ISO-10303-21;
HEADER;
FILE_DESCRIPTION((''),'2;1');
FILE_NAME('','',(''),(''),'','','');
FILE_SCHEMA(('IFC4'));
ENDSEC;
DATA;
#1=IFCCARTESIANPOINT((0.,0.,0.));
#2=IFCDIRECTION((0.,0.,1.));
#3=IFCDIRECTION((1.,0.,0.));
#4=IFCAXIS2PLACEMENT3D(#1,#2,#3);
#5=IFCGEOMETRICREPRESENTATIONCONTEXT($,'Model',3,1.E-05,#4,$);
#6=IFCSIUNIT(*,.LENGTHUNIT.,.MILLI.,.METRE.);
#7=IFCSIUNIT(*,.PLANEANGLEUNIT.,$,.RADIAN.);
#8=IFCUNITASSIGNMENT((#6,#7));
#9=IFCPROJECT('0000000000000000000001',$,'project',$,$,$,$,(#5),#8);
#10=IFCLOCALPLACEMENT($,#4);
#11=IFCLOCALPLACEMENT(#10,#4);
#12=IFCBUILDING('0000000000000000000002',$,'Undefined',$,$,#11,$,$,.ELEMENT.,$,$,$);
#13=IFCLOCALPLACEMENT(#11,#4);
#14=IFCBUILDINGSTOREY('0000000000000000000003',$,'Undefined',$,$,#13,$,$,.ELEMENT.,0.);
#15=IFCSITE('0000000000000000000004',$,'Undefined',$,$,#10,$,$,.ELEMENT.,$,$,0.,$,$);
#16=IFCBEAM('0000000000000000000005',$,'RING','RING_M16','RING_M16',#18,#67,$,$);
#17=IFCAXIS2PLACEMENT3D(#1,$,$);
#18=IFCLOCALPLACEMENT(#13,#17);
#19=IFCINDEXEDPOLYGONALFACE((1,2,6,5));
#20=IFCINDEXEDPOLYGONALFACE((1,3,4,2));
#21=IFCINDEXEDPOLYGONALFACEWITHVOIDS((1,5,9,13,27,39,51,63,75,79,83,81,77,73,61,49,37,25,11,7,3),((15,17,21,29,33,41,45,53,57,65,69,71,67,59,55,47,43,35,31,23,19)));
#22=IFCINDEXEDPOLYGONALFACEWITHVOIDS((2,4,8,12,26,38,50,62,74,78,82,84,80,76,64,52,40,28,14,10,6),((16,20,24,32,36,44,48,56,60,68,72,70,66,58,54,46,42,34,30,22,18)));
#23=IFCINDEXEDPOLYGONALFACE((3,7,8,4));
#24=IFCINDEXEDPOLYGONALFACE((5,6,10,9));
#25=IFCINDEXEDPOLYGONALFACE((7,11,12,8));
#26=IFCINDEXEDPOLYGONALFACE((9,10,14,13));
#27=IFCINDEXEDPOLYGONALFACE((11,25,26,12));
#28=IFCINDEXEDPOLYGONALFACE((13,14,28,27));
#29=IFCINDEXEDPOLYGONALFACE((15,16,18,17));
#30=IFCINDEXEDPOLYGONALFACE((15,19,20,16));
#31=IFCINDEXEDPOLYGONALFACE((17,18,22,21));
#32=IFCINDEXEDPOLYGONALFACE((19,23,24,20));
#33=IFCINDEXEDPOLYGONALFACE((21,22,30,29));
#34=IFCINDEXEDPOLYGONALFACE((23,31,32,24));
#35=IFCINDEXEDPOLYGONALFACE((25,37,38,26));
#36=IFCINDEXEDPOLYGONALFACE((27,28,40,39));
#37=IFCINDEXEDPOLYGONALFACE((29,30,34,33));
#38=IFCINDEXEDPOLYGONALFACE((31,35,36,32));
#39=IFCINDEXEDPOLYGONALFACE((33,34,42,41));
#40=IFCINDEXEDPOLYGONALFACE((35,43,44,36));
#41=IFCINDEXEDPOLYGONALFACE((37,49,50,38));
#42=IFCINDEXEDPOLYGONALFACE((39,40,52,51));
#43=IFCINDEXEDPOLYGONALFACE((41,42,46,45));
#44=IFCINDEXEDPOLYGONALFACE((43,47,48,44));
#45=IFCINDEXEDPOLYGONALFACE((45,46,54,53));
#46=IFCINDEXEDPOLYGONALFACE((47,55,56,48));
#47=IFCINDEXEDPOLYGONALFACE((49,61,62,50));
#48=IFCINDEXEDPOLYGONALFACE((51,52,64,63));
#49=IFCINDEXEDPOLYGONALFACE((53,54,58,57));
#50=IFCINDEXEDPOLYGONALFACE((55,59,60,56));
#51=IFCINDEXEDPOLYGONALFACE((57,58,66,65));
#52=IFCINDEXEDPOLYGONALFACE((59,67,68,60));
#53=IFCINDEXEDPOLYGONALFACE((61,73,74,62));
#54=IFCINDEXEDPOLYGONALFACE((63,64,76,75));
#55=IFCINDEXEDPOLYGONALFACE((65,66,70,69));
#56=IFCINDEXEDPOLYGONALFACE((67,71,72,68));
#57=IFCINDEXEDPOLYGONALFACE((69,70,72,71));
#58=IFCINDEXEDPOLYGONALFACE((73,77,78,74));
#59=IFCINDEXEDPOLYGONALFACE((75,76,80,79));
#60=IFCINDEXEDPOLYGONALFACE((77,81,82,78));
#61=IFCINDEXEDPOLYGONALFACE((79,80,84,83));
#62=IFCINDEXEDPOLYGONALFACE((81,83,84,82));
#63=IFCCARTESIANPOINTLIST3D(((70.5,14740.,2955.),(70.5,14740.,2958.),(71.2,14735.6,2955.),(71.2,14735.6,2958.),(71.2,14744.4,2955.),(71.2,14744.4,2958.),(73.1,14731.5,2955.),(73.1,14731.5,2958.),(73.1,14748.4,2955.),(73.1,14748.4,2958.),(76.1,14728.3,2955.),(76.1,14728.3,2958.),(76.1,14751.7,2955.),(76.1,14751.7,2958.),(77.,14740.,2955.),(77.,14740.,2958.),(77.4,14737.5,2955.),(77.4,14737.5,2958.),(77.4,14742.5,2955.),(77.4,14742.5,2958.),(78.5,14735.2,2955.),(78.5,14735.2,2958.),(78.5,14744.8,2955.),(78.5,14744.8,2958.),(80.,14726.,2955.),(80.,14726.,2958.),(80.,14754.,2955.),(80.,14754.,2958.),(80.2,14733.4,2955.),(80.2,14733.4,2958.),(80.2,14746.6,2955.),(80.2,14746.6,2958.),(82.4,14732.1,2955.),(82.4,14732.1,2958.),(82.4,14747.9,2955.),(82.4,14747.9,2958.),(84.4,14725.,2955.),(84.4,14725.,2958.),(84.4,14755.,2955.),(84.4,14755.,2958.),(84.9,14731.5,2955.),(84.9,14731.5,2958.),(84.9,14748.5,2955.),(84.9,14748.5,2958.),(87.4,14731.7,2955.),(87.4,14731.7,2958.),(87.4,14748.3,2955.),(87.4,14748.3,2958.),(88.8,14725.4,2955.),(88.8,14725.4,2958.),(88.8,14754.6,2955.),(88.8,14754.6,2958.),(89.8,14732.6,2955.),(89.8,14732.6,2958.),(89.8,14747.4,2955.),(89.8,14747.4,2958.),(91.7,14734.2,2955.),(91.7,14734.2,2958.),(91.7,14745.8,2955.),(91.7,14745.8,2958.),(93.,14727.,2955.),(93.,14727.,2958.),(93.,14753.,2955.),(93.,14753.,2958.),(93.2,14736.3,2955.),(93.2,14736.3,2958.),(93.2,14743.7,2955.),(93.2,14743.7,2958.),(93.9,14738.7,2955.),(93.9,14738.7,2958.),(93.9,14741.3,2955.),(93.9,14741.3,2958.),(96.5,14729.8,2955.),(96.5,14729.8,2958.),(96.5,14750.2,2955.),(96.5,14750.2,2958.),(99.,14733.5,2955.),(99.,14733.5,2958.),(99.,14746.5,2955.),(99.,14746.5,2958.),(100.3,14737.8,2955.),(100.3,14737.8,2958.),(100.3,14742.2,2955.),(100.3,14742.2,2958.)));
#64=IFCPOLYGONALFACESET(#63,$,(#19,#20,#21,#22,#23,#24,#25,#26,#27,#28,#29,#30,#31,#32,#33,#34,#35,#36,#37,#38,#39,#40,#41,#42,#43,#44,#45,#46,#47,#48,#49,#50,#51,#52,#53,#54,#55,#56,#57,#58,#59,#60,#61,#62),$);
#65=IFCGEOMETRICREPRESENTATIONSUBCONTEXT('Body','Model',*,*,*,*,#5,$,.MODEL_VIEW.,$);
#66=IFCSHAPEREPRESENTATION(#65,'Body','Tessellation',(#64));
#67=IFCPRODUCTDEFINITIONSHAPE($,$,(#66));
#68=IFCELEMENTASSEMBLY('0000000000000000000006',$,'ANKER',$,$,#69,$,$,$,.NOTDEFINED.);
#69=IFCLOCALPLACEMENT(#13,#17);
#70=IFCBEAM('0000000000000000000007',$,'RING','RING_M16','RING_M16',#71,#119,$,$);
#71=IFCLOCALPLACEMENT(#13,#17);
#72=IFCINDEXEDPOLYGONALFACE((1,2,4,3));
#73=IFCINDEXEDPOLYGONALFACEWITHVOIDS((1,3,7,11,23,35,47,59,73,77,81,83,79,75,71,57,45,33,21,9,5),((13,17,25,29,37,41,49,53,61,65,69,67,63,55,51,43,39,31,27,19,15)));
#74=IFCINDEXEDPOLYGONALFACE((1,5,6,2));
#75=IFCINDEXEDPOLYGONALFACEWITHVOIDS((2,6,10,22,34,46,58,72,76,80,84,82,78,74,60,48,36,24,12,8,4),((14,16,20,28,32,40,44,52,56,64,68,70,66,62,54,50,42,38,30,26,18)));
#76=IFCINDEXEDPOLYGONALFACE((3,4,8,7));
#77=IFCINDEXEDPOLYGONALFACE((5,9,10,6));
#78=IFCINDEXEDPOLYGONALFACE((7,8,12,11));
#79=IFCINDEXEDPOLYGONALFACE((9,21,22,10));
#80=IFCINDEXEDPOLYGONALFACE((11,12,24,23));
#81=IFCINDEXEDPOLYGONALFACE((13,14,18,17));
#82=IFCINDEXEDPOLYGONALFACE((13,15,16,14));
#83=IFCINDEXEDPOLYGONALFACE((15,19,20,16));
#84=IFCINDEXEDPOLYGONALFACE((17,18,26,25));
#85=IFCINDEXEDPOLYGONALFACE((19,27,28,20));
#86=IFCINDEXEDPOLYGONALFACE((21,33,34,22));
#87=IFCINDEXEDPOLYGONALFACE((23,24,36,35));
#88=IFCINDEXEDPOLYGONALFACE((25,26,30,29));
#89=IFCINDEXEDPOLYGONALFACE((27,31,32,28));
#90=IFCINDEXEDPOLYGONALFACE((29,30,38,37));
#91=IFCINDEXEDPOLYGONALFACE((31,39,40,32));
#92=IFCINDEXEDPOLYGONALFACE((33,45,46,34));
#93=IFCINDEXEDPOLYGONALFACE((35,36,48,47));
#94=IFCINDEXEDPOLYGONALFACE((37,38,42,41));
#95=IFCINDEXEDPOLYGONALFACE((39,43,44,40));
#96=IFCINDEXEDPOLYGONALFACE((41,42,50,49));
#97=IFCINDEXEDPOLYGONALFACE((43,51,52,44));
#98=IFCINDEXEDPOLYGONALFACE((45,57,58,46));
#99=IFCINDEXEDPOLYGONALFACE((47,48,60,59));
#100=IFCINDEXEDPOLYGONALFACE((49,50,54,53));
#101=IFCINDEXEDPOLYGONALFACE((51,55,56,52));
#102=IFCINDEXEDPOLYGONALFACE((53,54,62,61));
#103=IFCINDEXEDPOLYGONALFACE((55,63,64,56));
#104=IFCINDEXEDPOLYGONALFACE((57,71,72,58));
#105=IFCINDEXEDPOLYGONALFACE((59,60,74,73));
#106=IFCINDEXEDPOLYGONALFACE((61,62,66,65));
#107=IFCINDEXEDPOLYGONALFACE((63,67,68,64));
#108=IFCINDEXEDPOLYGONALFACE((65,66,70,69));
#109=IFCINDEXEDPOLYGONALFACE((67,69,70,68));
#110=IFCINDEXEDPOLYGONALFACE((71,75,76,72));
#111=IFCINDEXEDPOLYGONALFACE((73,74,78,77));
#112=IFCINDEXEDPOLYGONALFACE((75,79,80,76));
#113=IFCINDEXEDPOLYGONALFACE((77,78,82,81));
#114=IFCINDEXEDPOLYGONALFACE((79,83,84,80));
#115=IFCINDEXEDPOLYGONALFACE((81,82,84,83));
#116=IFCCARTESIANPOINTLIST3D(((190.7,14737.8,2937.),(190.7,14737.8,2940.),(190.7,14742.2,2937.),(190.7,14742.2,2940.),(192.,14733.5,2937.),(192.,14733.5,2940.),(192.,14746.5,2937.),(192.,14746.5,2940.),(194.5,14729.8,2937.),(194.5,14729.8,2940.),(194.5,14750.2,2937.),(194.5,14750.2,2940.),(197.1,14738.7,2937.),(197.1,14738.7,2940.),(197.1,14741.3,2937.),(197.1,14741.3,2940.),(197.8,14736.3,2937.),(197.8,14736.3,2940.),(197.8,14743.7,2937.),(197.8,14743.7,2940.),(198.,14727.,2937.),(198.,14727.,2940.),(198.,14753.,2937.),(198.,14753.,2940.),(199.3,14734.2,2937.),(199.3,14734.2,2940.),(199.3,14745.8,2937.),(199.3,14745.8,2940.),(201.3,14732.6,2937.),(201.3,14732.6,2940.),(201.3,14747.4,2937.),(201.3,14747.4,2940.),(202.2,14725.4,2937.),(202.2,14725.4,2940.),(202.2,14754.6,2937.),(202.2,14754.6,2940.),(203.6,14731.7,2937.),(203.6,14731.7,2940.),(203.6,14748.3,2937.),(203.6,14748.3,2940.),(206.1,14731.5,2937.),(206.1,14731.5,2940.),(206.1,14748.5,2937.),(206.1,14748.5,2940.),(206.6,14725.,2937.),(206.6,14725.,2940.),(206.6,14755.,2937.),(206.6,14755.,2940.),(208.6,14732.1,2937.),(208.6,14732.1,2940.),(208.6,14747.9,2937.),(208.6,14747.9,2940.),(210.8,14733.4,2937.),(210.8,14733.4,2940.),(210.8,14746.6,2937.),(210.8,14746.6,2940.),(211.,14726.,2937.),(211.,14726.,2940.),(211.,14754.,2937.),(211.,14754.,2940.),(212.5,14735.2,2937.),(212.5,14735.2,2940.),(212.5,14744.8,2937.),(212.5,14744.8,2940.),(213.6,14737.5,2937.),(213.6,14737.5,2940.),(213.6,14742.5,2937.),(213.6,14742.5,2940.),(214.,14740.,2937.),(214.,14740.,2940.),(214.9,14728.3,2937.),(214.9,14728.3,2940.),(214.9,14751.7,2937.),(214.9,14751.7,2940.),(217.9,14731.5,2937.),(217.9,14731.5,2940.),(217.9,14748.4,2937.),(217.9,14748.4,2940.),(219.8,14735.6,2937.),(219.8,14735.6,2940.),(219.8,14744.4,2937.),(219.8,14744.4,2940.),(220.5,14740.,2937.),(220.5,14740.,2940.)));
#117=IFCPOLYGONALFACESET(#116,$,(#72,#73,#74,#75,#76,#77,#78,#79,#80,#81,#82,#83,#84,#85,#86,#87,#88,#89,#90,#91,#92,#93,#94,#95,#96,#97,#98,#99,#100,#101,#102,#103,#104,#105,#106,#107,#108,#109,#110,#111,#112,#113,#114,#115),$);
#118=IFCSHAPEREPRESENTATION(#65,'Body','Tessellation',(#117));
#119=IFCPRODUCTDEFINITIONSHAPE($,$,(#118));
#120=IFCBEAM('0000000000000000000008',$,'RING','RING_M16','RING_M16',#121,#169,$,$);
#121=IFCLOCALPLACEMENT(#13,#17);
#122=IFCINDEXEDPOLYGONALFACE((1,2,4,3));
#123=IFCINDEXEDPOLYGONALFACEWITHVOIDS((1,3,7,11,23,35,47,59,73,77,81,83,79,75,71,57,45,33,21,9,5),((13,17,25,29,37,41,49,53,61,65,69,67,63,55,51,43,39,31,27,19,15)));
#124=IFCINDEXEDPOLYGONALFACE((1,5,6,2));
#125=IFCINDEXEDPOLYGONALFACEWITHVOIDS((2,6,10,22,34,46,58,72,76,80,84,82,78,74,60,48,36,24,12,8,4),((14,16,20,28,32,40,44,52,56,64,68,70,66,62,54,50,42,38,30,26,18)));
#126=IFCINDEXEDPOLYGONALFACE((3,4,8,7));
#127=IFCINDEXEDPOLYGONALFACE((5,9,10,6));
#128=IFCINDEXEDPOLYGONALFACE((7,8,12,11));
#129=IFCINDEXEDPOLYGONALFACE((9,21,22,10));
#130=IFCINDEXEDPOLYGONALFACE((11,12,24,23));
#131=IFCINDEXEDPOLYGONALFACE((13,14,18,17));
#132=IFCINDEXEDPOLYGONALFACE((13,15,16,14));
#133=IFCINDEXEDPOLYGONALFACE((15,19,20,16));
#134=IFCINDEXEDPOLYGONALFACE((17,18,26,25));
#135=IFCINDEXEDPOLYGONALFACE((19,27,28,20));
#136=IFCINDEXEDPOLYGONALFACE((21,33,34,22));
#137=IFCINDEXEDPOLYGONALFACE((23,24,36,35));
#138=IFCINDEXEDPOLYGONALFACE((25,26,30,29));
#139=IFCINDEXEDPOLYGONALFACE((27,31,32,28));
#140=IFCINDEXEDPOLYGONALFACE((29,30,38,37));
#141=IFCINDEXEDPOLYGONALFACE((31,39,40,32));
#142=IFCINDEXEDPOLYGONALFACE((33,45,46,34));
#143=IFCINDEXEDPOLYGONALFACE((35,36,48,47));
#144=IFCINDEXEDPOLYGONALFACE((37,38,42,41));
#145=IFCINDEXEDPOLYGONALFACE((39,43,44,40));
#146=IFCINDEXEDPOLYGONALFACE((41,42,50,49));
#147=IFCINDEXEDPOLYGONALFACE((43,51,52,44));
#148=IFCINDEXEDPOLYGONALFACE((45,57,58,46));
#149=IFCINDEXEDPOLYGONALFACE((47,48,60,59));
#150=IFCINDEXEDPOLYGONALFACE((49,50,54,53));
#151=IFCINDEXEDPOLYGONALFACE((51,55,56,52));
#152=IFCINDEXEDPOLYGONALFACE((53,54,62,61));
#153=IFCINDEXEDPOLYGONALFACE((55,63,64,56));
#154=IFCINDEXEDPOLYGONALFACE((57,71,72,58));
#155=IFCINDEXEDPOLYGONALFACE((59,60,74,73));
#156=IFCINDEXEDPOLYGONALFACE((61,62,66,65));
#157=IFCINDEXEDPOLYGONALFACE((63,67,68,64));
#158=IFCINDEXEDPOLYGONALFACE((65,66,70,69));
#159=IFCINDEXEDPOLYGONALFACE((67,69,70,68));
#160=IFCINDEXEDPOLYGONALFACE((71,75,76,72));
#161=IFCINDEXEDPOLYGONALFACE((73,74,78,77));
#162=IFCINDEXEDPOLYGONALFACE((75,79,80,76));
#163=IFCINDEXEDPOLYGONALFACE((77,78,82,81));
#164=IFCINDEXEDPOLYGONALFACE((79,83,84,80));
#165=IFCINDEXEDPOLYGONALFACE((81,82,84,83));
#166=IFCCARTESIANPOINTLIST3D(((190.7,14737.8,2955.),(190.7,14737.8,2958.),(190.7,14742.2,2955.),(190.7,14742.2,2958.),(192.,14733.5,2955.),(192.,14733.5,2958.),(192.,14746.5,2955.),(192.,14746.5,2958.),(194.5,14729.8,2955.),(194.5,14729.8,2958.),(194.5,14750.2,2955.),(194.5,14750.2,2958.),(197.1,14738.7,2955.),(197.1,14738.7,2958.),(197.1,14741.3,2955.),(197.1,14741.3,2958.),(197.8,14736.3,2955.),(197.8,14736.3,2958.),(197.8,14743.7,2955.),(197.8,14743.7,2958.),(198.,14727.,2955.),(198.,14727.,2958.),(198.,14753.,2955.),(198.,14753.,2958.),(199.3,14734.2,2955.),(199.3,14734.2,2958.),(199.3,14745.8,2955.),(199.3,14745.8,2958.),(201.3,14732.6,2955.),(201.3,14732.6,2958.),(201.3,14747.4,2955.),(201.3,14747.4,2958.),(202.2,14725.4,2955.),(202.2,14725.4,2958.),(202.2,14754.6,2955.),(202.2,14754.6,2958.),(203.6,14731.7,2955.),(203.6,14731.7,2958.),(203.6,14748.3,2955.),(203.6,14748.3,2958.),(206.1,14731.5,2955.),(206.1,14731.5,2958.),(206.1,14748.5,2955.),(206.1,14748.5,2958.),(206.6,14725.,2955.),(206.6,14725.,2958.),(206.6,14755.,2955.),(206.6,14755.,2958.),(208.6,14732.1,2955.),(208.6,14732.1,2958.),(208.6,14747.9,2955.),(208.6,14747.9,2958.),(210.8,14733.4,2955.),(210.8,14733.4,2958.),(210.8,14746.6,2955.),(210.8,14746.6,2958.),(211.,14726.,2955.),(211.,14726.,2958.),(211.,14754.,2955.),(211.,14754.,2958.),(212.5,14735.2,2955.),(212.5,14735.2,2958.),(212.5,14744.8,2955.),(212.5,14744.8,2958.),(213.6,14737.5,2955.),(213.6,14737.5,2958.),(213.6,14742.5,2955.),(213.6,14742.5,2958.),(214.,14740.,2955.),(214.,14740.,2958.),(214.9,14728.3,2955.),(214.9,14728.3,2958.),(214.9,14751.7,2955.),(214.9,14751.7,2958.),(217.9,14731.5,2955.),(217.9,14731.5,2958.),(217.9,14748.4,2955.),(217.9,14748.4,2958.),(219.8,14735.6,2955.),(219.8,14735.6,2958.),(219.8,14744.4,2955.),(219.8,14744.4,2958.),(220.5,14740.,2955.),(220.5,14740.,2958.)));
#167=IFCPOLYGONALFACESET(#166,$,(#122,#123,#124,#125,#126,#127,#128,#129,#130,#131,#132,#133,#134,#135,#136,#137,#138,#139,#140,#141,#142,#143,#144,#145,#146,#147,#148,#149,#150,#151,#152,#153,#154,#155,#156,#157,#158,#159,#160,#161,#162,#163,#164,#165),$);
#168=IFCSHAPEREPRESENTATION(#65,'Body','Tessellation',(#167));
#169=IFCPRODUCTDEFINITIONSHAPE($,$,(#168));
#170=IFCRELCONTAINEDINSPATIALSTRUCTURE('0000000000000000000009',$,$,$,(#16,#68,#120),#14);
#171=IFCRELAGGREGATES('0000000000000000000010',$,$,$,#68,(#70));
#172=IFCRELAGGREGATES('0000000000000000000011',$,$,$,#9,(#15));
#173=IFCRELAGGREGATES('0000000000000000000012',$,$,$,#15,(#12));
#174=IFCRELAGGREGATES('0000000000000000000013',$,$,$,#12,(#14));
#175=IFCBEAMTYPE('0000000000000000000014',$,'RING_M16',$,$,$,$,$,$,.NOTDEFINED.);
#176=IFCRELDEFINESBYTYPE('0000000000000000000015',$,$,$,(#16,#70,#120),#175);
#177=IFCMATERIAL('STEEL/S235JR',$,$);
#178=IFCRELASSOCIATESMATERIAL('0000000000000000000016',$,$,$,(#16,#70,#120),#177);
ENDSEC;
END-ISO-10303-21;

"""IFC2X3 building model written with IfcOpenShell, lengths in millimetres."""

from ifc_helpers import new_model, si_unit, frame, origin_with_axes, origin_2d_with_axis, place, context, subcontext, project, spatial, hollow_circle, extrude, material, type_object, element, aggregate, save


model = new_model("IFC2X3")

# Units and contexts
model_context = context("Model", 3, precision=1e-05, world=origin_with_axes())
body_context = subcontext(model_context, "Body", "Model", "MODEL_VIEW")
ifc_project = project(units=[si_unit("LENGTHUNIT", "METRE", prefix="MILLI"), si_unit("PLANEANGLEUNIT", "RADIAN")], contexts=[model_context])

# Site, building, storey
site_placement = place(None, origin_with_axes())
site = spatial("IfcSite", under=ifc_project, at=site_placement, Name="Undefined", CompositionType="ELEMENT", RefElevation=0.0)
building_placement = place(site_placement, origin_with_axes())
building = spatial("IfcBuilding", under=site, at=building_placement, Name="Undefined", CompositionType="ELEMENT")
storey_placement = place(building_placement, origin_with_axes())
storey = spatial("IfcBuildingStorey", under=building, at=storey_placement, Name="Undefined", CompositionType="ELEMENT", Elevation=0.0)

# Shared definitions
ifc_material = material(Name="STEEL/S235JR")

# Shared definitions
beam_type_1 = type_object("IfcBeamType", Name="RING_M16", PredefinedType="NOTDEFINED")

# Beam
beam_1_placement = place(storey_placement, frame((85.5, 14740.0, 2958.0), z_axis=(0.0, -1.0, 0.0), x_axis=(0.0, 0.0, -1.0)))
element("IfcBeam", 1, at=beam_1_placement, inside=storey, type_object=beam_type_1, material=ifc_material, Name="RING", Description="RING_M16", ObjectType="RING_M16", context=body_context, shape_type="SweptSolid", body=[
    extrude(hollow_circle(Radius=15.0, WallThickness=6.5, at=origin_2d_with_axis()), frame((3.0, 0.0, 0.0), z_axis=(-1.0, 0.0, 0.0), x_axis=(0.0, -1.0, 0.0)), (0.0, 0.0, 1.0), 3.0),
])

# Element assembly, beam
assembly_1_placement = place(storey_placement, frame((205.5, 14740.0, 2995.0), z_axis=(0.0, 1.0, 0.0), x_axis=(0.0, 0.0, -1.0)))
assembly_1 = element("IfcElementAssembly", 2, at=assembly_1_placement, inside=storey, Name="ANKER", PredefinedType="NOTDEFINED")
beam_2_placement = place(storey_placement, frame((205.5, 14740.0, 2940.0), z_axis=(0.0, 1.0, 0.0), x_axis=(0.0, 0.0, -1.0)))
beam_2 = element("IfcBeam", 3, at=beam_2_placement, type_object=beam_type_1, material=ifc_material, Name="RING", Description="RING_M16", ObjectType="RING_M16", context=body_context, shape_type="SweptSolid", body=[
    extrude(hollow_circle(Radius=15.0, WallThickness=6.5, at=origin_2d_with_axis()), frame((3.0, 0.0, 0.0), z_axis=(-1.0, 0.0, 0.0), x_axis=(0.0, -1.0, 0.0)), (0.0, 0.0, 1.0), 3.0),
])
aggregate(assembly_1, [beam_2])

# Beam
beam_3_placement = place(storey_placement, frame((205.5, 14740.0, 2958.0), z_axis=(0.0, 1.0, 0.0), x_axis=(0.0, 0.0, -1.0)))
element("IfcBeam", 4, at=beam_3_placement, inside=storey, type_object=beam_type_1, material=ifc_material, Name="RING", Description="RING_M16", ObjectType="RING_M16", context=body_context, shape_type="SweptSolid", body=[
    extrude(hollow_circle(Radius=15.0, WallThickness=6.5, at=origin_2d_with_axis()), frame((3.0, 0.0, 0.0), z_axis=(-1.0, 0.0, 0.0), x_axis=(0.0, -1.0, 0.0)), (0.0, 0.0, 1.0), 3.0),
])

save(model, "model.ifc")
